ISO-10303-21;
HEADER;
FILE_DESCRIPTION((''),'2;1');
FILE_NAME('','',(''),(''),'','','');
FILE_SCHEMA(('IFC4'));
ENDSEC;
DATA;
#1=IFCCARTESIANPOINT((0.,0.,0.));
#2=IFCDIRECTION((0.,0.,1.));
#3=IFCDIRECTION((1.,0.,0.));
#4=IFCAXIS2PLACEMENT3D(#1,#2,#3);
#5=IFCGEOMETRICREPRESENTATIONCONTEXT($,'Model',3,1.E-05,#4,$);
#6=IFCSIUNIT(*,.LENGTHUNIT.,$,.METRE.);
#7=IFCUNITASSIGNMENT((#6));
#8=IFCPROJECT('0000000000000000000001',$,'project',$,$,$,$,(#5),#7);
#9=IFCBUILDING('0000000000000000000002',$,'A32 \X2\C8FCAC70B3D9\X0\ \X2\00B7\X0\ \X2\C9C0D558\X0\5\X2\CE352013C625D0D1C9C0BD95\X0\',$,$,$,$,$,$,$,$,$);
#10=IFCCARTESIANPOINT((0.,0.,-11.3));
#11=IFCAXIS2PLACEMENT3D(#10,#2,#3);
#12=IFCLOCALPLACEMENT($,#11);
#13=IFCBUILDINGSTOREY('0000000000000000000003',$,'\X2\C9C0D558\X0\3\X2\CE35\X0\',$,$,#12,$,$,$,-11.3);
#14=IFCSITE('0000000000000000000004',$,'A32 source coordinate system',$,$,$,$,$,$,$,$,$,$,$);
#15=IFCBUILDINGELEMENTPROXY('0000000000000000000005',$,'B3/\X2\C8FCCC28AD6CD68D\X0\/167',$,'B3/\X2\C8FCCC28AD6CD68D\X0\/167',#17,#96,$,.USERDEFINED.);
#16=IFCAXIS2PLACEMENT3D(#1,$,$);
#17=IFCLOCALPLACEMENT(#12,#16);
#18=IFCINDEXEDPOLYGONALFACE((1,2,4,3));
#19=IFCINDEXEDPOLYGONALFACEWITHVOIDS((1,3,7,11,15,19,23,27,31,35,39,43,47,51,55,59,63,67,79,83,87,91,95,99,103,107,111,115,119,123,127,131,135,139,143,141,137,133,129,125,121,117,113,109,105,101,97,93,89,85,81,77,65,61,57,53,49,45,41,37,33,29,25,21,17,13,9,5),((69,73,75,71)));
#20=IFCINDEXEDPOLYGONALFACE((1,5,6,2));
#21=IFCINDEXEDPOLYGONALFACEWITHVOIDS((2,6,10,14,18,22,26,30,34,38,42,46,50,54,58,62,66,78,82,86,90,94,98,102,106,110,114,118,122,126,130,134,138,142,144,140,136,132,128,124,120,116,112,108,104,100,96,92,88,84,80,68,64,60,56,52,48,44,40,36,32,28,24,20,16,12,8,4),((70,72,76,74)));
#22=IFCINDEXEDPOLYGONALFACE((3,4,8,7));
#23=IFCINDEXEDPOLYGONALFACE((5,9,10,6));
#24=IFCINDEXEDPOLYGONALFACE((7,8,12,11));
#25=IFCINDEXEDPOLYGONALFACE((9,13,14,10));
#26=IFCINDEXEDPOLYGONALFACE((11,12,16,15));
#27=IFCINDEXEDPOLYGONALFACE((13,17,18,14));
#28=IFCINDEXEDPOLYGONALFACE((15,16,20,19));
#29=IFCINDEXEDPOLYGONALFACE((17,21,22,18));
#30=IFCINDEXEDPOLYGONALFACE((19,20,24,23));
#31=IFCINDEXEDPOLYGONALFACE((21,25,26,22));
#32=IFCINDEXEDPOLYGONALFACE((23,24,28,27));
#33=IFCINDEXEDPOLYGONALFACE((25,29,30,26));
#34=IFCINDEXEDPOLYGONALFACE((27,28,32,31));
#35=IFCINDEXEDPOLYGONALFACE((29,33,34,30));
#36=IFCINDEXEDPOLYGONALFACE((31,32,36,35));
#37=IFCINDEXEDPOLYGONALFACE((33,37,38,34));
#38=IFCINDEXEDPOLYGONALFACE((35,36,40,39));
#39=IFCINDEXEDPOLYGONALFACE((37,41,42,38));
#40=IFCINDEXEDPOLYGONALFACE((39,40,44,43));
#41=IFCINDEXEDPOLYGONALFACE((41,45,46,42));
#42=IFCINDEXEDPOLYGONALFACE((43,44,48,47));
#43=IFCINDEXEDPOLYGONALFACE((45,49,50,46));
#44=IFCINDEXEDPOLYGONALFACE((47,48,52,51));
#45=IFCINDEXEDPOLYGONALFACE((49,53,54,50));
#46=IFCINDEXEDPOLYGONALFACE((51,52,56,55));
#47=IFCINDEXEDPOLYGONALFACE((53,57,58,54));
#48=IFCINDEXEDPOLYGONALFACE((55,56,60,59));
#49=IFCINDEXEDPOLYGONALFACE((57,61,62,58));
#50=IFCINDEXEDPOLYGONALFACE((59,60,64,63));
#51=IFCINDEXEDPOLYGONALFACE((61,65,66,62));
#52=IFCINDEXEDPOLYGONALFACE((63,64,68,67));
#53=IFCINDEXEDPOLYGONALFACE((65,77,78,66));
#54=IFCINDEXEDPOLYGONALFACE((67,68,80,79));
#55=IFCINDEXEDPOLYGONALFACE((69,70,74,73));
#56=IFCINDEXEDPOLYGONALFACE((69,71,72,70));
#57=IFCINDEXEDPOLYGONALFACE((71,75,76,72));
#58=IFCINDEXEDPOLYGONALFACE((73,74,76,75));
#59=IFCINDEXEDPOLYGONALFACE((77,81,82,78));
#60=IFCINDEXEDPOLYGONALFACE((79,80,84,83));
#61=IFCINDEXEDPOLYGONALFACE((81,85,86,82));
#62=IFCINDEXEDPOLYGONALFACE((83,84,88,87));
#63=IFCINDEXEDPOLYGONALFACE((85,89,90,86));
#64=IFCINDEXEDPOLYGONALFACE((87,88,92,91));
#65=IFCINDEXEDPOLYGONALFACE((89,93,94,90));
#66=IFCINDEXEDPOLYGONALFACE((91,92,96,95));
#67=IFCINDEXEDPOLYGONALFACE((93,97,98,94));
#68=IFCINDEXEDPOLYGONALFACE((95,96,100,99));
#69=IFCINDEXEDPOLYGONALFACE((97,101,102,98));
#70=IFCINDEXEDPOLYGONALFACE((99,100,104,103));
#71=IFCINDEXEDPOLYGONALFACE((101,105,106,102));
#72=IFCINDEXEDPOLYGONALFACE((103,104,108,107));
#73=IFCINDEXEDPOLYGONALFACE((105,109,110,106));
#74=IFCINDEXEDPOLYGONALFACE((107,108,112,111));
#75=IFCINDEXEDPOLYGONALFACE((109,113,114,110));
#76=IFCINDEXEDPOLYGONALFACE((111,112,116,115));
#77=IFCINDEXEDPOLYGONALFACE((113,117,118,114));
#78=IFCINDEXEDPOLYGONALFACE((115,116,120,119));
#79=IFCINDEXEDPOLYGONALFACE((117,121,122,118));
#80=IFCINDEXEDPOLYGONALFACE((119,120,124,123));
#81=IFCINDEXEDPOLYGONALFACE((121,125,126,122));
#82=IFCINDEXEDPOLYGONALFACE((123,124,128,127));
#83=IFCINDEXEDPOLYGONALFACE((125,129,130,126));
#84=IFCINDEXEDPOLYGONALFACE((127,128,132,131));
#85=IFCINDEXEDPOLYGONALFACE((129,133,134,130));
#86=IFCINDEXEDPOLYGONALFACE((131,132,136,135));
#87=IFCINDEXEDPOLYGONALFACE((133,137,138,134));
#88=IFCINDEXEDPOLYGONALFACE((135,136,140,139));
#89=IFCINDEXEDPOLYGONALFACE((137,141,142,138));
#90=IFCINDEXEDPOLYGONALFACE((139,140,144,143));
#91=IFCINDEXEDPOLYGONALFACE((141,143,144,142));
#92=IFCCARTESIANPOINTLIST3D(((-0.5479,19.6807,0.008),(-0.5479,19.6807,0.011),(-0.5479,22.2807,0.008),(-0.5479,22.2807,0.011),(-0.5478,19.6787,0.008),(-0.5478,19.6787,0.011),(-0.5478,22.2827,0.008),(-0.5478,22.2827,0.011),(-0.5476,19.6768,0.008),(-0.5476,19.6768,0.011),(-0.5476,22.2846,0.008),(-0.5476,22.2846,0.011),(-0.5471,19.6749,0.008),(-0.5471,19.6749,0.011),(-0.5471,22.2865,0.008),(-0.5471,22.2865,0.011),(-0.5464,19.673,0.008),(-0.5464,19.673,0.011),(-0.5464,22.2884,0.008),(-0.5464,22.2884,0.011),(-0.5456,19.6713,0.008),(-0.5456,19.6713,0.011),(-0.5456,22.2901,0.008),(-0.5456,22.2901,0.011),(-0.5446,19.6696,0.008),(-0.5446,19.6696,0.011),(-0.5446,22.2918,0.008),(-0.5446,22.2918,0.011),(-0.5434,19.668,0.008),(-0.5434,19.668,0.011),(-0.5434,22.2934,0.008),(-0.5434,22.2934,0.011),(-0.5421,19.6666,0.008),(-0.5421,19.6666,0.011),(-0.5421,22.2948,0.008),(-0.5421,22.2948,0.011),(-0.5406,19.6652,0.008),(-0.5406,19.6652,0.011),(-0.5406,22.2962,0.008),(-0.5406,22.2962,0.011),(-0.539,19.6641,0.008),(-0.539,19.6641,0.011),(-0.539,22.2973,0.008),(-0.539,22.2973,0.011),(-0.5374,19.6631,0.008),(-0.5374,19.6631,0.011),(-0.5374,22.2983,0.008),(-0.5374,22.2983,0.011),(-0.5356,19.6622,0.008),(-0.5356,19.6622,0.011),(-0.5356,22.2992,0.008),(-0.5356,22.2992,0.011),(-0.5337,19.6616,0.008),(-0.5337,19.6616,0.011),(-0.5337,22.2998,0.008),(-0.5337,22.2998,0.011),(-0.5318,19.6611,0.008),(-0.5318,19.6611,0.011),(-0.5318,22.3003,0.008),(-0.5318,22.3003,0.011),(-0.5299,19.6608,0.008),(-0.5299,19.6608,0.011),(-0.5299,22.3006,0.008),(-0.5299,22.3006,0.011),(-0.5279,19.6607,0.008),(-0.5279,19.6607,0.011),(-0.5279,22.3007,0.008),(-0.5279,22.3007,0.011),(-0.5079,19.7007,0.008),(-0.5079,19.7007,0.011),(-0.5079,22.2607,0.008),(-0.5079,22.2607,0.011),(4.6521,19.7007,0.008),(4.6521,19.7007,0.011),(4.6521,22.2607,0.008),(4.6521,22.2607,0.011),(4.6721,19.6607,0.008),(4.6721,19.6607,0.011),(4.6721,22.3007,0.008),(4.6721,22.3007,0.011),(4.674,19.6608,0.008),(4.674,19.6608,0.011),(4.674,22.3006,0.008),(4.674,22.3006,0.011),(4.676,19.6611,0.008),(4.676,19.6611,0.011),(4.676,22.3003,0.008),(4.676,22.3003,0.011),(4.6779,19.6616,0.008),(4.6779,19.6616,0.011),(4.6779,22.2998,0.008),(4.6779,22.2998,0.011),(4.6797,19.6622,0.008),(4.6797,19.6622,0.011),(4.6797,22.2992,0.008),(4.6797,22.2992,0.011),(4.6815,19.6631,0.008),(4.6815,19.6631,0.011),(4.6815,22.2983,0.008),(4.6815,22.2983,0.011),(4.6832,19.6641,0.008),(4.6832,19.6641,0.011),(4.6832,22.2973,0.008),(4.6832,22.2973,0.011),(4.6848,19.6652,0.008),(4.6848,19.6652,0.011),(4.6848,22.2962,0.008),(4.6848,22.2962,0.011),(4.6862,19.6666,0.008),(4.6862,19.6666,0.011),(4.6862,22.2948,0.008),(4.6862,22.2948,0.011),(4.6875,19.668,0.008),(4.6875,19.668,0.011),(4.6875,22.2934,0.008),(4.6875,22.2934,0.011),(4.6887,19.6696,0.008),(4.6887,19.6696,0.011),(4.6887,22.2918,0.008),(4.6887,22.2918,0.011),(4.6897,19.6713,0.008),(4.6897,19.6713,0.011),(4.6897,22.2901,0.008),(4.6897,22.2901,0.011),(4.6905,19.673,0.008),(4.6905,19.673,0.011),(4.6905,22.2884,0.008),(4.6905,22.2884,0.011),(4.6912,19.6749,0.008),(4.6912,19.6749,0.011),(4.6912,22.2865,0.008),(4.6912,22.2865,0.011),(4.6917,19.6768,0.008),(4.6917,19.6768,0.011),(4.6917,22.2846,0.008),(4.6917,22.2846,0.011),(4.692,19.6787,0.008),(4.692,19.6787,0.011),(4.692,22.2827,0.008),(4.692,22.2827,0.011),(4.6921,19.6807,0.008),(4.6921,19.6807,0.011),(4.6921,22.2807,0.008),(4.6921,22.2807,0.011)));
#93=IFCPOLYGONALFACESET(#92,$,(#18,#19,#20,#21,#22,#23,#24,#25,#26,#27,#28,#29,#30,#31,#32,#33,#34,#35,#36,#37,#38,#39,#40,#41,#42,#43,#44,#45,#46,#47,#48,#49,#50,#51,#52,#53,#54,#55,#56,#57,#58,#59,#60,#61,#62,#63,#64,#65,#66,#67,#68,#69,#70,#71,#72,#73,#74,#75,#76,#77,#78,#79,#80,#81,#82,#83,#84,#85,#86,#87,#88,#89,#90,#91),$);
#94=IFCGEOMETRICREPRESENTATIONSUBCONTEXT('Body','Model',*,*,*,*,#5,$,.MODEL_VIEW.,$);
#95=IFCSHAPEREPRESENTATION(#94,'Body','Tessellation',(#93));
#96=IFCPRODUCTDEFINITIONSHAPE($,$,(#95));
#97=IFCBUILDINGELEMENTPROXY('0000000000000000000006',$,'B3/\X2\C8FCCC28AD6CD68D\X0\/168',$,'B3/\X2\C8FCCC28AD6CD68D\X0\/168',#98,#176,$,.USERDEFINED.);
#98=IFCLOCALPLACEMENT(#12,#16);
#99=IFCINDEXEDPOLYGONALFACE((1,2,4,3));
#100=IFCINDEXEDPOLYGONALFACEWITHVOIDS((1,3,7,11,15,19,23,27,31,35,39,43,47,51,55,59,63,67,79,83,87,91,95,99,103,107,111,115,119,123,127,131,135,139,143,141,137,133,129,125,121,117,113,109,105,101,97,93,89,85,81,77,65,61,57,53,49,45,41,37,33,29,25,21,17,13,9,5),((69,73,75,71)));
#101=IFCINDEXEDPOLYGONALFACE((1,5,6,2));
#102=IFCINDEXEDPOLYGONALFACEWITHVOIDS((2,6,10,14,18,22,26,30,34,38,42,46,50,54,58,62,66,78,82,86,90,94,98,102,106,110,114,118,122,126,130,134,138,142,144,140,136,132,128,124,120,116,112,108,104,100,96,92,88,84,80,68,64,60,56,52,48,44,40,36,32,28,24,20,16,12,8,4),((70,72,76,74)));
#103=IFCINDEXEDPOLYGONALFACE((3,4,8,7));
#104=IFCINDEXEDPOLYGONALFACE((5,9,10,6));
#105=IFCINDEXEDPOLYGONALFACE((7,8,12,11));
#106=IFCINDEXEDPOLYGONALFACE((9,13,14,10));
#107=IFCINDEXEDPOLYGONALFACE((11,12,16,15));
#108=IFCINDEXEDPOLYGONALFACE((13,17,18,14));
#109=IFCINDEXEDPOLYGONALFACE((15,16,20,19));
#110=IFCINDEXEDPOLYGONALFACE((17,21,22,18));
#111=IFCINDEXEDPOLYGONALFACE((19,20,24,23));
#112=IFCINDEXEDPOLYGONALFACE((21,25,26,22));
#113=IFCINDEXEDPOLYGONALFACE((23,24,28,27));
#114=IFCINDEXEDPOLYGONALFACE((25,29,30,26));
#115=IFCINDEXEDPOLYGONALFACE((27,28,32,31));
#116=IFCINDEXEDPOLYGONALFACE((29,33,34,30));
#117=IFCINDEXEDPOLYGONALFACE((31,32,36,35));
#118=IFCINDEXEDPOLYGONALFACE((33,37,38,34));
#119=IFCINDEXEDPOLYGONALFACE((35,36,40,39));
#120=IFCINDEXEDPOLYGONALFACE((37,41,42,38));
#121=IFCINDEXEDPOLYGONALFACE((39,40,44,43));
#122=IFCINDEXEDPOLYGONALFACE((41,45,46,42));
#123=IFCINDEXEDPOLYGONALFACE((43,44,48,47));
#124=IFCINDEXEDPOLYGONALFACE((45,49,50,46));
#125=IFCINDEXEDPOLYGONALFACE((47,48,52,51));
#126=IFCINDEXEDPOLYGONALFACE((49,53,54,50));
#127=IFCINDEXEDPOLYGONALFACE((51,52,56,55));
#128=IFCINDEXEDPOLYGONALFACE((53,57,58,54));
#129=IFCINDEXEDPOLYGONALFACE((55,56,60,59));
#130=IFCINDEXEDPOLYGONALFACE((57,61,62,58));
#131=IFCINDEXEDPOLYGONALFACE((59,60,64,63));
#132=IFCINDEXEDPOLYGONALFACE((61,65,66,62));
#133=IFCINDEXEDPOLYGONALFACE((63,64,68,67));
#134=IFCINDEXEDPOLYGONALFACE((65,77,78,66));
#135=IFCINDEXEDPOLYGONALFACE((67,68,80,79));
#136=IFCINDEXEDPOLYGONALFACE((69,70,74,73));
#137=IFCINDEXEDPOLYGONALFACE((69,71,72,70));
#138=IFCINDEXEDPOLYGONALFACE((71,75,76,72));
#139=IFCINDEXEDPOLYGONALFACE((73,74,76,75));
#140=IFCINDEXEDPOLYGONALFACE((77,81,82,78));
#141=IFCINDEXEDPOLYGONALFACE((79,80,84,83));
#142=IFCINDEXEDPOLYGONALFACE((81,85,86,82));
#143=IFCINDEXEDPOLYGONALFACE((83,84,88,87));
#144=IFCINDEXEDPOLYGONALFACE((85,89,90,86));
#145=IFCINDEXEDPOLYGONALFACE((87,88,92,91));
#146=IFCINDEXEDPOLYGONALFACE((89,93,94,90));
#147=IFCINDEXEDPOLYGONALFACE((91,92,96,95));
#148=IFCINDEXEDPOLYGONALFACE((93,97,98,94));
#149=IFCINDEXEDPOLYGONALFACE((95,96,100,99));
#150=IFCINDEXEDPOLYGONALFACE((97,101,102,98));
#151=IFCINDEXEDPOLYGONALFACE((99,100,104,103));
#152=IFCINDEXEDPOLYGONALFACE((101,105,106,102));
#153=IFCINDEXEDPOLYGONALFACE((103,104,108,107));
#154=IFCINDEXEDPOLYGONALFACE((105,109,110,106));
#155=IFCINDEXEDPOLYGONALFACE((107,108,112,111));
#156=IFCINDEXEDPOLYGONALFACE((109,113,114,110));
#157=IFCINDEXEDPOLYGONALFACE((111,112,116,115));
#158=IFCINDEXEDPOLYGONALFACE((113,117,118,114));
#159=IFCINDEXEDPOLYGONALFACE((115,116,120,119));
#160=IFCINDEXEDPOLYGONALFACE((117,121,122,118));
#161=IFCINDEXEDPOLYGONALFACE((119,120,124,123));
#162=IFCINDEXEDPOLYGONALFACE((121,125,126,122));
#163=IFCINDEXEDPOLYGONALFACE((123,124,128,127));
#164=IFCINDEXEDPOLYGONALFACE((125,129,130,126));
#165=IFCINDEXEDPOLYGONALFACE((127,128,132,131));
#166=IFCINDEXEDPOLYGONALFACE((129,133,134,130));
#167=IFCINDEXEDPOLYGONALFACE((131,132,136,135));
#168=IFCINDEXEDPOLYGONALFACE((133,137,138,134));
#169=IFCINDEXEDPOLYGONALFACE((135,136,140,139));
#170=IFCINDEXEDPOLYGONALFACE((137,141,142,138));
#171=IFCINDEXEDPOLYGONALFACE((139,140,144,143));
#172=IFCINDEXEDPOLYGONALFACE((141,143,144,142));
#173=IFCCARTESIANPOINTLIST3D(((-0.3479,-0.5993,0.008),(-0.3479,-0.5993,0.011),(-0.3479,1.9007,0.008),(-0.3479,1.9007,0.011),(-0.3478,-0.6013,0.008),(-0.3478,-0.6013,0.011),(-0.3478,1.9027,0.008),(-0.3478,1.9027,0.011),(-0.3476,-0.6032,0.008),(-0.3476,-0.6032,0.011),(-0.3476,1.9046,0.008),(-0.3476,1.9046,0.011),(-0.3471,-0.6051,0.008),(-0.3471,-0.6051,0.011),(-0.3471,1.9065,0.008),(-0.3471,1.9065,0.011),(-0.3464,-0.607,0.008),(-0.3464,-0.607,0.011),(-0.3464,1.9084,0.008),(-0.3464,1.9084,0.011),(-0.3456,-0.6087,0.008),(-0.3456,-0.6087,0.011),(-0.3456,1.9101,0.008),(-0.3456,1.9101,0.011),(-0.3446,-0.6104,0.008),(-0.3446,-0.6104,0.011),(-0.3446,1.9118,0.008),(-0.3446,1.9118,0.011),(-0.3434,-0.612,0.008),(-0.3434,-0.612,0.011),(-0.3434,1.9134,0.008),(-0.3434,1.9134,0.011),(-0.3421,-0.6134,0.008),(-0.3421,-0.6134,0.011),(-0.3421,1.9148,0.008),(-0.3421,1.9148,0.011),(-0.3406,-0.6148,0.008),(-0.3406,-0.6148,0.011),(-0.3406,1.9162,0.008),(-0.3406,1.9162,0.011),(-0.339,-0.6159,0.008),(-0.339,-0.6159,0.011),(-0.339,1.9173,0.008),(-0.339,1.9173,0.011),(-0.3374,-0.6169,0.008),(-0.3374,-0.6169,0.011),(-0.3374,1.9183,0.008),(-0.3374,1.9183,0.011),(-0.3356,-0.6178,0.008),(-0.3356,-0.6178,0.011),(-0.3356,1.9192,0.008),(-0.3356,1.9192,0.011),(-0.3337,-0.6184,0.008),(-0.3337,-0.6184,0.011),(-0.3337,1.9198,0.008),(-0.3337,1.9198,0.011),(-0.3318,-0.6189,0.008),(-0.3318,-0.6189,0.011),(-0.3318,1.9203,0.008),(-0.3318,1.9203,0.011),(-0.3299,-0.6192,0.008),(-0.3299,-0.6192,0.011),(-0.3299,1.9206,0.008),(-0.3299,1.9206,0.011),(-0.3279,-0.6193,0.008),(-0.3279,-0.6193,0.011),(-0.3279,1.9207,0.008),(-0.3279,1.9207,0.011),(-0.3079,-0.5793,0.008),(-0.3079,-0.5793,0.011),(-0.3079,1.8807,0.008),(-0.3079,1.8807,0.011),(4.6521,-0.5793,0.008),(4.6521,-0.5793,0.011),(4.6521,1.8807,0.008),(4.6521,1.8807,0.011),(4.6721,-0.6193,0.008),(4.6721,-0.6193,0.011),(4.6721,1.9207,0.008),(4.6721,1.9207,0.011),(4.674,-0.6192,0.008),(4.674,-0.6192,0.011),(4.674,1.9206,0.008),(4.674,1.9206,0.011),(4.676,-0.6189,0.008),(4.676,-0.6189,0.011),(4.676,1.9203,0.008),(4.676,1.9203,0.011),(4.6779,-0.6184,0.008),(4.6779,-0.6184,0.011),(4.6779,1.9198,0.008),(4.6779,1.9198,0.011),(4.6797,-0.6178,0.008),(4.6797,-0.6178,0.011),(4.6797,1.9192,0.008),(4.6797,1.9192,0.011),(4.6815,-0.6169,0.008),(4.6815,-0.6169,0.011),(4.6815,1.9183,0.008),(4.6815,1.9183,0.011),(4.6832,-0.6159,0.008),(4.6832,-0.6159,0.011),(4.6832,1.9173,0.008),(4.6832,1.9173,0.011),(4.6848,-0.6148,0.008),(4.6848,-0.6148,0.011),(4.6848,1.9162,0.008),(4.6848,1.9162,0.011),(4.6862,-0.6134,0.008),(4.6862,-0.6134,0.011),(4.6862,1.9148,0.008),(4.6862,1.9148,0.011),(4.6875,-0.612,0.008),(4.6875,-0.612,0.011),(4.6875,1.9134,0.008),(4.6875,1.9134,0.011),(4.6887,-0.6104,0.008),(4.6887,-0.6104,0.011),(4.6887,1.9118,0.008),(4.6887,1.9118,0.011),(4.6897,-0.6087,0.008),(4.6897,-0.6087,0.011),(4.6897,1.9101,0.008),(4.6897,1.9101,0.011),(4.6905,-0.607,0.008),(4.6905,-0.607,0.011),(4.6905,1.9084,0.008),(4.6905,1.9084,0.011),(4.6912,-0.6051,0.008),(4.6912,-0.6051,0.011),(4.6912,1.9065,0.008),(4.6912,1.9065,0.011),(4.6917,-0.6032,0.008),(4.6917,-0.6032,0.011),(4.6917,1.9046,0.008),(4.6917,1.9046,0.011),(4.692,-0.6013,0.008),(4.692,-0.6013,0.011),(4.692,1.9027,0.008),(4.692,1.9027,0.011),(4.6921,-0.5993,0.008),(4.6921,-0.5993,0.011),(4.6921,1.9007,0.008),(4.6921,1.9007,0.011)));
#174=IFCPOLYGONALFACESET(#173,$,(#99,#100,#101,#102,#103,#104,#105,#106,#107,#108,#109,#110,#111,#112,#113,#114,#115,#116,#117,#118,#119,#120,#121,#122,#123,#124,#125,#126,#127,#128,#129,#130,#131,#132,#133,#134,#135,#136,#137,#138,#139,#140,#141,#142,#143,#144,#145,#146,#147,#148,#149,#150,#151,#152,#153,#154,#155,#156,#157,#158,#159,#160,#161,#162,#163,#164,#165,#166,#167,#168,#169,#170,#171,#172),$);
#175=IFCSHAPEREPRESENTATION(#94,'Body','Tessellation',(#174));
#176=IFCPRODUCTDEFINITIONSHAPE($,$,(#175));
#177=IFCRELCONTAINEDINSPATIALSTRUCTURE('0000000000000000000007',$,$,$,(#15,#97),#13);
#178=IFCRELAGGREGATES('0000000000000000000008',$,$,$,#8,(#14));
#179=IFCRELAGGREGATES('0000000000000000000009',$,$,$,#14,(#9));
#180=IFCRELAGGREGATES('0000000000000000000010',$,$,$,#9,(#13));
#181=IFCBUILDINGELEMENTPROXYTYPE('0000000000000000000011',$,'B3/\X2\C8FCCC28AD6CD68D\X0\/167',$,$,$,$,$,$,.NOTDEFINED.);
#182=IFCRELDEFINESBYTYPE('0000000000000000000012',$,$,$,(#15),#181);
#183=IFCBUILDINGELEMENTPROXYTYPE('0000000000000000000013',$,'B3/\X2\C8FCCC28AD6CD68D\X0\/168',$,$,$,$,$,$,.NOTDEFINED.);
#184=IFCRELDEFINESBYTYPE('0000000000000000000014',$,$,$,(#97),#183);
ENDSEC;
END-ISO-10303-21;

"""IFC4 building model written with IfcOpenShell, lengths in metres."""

from ifc_helpers import new_model, si_unit, frame, origin, origin_with_axes, place, context, subcontext, project, spatial, polyline, outline, extrude, source, transform, mapped, type_object, type_shapes, element, save


model = new_model("IFC4")

# Units and contexts
model_context = context("Model", 3, precision=1e-05, world=origin_with_axes())
body_context = subcontext(model_context, "Body", "Model", "MODEL_VIEW")
ifc_project = project(units=[si_unit("LENGTHUNIT", "METRE")], contexts=[model_context])

# Site, building, storey
site = spatial("IfcSite", under=ifc_project, Name="A32 source coordinate system")
building = spatial("IfcBuilding", under=site, Name="A32 주거동 · 지하5층–옥탑지붕")
storey_placement = place(None, frame((0.0, 0.0, -11.3), z_axis=(0.0, 0.0, 1.0), x_axis=(1.0, 0.0, 0.0)))
storey = spatial("IfcBuildingStorey", under=building, at=storey_placement, Name="지하3층", Elevation=-11.3)

# Building element proxies
building_element_proxy_type_1 = type_object("IfcBuildingElementProxyType", Name="B3/주차구획/167", PredefinedType="NOTDEFINED")
shared_shape_1 = source(origin(), body_context, "Body", "SweptSolid", [
    extrude(outline(polyline([(-0.5279, 19.6607), (-0.5299, 19.6608), (-0.5318, 19.6611), (-0.5337, 19.6616), (-0.5356, 19.6622), (-0.5374, 19.6631), (-0.539, 19.6641), (-0.5406, 19.6652), (-0.5421, 19.6666), (-0.5434, 19.668), (-0.5446, 19.6696), (-0.5456, 19.6713), (-0.5464, 19.673), (-0.5471, 19.6749), (-0.5476, 19.6768), (-0.5478, 19.6787), (-0.5479, 19.6807), (-0.5479, 22.2807), (-0.5478, 22.2827), (-0.5476, 22.2846), (-0.5471, 22.2865), (-0.5464, 22.2884), (-0.5456, 22.2901), (-0.5446, 22.2918), (-0.5434, 22.2934), (-0.5421, 22.2948), (-0.5406, 22.2962), (-0.539, 22.2973), (-0.5374, 22.2983), (-0.5356, 22.2992), (-0.5337, 22.2998), (-0.5318, 22.3003), (-0.5299, 22.3006), (-0.5279, 22.3007), (4.6721, 22.3007), (4.674, 22.3006), (4.676, 22.3003), (4.6779, 22.2998), (4.6797, 22.2992), (4.6815, 22.2983), (4.6832, 22.2973), (4.6848, 22.2962), (4.6862, 22.2948), (4.6875, 22.2934), (4.6887, 22.2918), (4.6897, 22.2901), (4.6905, 22.2884), (4.6912, 22.2865), (4.6917, 22.2846), (4.692, 22.2827), (4.6921, 22.2807), (4.6921, 19.6807), (4.692, 19.6787), (4.6917, 19.6768), (4.6912, 19.6749), (4.6905, 19.673), (4.6897, 19.6713), (4.6887, 19.6696), (4.6875, 19.668), (4.6862, 19.6666), (4.6848, 19.6652), (4.6832, 19.6641), (4.6815, 19.6631), (4.6797, 19.6622), (4.6779, 19.6616), (4.676, 19.6611), (4.674, 19.6608), (4.6721, 19.6607), (-0.5279, 19.6607)]), holes=[polyline([(-0.5079, 19.7007), (4.6521, 19.7007), (4.6521, 22.2607), (-0.5079, 22.2607), (-0.5079, 19.7007)])]), frame((0.0, 0.0, 0.008)), (0.0, 0.0, 1.0), 0.003),
])
type_shapes(building_element_proxy_type_1, [shared_shape_1])
proxy_1_placement = place(storey_placement, origin_with_axes())
element("IfcBuildingElementProxy", 1, at=proxy_1_placement, inside=storey, type_object=building_element_proxy_type_1, Name="B3/주차구획/167", ObjectType="B3/주차구획/167", PredefinedType="USERDEFINED", context=body_context, shape_type="MappedRepresentation", body=[
    mapped(shared_shape_1, transform((0.0, 0.0, 0.0), scale=1.0)),
])
building_element_proxy_type_2 = type_object("IfcBuildingElementProxyType", Name="B3/주차구획/168", PredefinedType="NOTDEFINED")
shared_shape_2 = source(origin(), body_context, "Body", "SweptSolid", [
    extrude(outline(polyline([(-0.3279, -0.6193), (-0.3299, -0.6192), (-0.3318, -0.6189), (-0.3337, -0.6184), (-0.3356, -0.6178), (-0.3374, -0.6169), (-0.339, -0.6159), (-0.3406, -0.6148), (-0.3421, -0.6134), (-0.3434, -0.612), (-0.3446, -0.6104), (-0.3456, -0.6087), (-0.3464, -0.607), (-0.3471, -0.6051), (-0.3476, -0.6032), (-0.3478, -0.6013), (-0.3479, -0.5993), (-0.3479, 1.9007), (-0.3478, 1.9027), (-0.3476, 1.9046), (-0.3471, 1.9065), (-0.3464, 1.9084), (-0.3456, 1.9101), (-0.3446, 1.9118), (-0.3434, 1.9134), (-0.3421, 1.9148), (-0.3406, 1.9162), (-0.339, 1.9173), (-0.3374, 1.9183), (-0.3356, 1.9192), (-0.3337, 1.9198), (-0.3318, 1.9203), (-0.3299, 1.9206), (-0.3279, 1.9207), (4.6721, 1.9207), (4.674, 1.9206), (4.676, 1.9203), (4.6779, 1.9198), (4.6797, 1.9192), (4.6815, 1.9183), (4.6832, 1.9173), (4.6848, 1.9162), (4.6862, 1.9148), (4.6875, 1.9134), (4.6887, 1.9118), (4.6897, 1.9101), (4.6905, 1.9084), (4.6912, 1.9065), (4.6917, 1.9046), (4.692, 1.9027), (4.6921, 1.9007), (4.6921, -0.5993), (4.692, -0.6013), (4.6917, -0.6032), (4.6912, -0.6051), (4.6905, -0.607), (4.6897, -0.6087), (4.6887, -0.6104), (4.6875, -0.612), (4.6862, -0.6134), (4.6848, -0.6148), (4.6832, -0.6159), (4.6815, -0.6169), (4.6797, -0.6178), (4.6779, -0.6184), (4.676, -0.6189), (4.674, -0.6192), (4.6721, -0.6193), (-0.3279, -0.6193)]), holes=[polyline([(-0.3079, -0.5793), (4.6521, -0.5793), (4.6521, 1.8807), (-0.3079, 1.8807), (-0.3079, -0.5793)])]), frame((0.0, 0.0, 0.008)), (0.0, 0.0, 1.0), 0.003),
])
type_shapes(building_element_proxy_type_2, [shared_shape_2])
proxy_2_placement = place(storey_placement, origin_with_axes())
element("IfcBuildingElementProxy", 2, at=proxy_2_placement, inside=storey, type_object=building_element_proxy_type_2, Name="B3/주차구획/168", ObjectType="B3/주차구획/168", PredefinedType="USERDEFINED", context=body_context, shape_type="MappedRepresentation", body=[
    mapped(shared_shape_2, transform((0.0, 0.0, 0.0), scale=1.0)),
])

save(model, "model.ifc")
